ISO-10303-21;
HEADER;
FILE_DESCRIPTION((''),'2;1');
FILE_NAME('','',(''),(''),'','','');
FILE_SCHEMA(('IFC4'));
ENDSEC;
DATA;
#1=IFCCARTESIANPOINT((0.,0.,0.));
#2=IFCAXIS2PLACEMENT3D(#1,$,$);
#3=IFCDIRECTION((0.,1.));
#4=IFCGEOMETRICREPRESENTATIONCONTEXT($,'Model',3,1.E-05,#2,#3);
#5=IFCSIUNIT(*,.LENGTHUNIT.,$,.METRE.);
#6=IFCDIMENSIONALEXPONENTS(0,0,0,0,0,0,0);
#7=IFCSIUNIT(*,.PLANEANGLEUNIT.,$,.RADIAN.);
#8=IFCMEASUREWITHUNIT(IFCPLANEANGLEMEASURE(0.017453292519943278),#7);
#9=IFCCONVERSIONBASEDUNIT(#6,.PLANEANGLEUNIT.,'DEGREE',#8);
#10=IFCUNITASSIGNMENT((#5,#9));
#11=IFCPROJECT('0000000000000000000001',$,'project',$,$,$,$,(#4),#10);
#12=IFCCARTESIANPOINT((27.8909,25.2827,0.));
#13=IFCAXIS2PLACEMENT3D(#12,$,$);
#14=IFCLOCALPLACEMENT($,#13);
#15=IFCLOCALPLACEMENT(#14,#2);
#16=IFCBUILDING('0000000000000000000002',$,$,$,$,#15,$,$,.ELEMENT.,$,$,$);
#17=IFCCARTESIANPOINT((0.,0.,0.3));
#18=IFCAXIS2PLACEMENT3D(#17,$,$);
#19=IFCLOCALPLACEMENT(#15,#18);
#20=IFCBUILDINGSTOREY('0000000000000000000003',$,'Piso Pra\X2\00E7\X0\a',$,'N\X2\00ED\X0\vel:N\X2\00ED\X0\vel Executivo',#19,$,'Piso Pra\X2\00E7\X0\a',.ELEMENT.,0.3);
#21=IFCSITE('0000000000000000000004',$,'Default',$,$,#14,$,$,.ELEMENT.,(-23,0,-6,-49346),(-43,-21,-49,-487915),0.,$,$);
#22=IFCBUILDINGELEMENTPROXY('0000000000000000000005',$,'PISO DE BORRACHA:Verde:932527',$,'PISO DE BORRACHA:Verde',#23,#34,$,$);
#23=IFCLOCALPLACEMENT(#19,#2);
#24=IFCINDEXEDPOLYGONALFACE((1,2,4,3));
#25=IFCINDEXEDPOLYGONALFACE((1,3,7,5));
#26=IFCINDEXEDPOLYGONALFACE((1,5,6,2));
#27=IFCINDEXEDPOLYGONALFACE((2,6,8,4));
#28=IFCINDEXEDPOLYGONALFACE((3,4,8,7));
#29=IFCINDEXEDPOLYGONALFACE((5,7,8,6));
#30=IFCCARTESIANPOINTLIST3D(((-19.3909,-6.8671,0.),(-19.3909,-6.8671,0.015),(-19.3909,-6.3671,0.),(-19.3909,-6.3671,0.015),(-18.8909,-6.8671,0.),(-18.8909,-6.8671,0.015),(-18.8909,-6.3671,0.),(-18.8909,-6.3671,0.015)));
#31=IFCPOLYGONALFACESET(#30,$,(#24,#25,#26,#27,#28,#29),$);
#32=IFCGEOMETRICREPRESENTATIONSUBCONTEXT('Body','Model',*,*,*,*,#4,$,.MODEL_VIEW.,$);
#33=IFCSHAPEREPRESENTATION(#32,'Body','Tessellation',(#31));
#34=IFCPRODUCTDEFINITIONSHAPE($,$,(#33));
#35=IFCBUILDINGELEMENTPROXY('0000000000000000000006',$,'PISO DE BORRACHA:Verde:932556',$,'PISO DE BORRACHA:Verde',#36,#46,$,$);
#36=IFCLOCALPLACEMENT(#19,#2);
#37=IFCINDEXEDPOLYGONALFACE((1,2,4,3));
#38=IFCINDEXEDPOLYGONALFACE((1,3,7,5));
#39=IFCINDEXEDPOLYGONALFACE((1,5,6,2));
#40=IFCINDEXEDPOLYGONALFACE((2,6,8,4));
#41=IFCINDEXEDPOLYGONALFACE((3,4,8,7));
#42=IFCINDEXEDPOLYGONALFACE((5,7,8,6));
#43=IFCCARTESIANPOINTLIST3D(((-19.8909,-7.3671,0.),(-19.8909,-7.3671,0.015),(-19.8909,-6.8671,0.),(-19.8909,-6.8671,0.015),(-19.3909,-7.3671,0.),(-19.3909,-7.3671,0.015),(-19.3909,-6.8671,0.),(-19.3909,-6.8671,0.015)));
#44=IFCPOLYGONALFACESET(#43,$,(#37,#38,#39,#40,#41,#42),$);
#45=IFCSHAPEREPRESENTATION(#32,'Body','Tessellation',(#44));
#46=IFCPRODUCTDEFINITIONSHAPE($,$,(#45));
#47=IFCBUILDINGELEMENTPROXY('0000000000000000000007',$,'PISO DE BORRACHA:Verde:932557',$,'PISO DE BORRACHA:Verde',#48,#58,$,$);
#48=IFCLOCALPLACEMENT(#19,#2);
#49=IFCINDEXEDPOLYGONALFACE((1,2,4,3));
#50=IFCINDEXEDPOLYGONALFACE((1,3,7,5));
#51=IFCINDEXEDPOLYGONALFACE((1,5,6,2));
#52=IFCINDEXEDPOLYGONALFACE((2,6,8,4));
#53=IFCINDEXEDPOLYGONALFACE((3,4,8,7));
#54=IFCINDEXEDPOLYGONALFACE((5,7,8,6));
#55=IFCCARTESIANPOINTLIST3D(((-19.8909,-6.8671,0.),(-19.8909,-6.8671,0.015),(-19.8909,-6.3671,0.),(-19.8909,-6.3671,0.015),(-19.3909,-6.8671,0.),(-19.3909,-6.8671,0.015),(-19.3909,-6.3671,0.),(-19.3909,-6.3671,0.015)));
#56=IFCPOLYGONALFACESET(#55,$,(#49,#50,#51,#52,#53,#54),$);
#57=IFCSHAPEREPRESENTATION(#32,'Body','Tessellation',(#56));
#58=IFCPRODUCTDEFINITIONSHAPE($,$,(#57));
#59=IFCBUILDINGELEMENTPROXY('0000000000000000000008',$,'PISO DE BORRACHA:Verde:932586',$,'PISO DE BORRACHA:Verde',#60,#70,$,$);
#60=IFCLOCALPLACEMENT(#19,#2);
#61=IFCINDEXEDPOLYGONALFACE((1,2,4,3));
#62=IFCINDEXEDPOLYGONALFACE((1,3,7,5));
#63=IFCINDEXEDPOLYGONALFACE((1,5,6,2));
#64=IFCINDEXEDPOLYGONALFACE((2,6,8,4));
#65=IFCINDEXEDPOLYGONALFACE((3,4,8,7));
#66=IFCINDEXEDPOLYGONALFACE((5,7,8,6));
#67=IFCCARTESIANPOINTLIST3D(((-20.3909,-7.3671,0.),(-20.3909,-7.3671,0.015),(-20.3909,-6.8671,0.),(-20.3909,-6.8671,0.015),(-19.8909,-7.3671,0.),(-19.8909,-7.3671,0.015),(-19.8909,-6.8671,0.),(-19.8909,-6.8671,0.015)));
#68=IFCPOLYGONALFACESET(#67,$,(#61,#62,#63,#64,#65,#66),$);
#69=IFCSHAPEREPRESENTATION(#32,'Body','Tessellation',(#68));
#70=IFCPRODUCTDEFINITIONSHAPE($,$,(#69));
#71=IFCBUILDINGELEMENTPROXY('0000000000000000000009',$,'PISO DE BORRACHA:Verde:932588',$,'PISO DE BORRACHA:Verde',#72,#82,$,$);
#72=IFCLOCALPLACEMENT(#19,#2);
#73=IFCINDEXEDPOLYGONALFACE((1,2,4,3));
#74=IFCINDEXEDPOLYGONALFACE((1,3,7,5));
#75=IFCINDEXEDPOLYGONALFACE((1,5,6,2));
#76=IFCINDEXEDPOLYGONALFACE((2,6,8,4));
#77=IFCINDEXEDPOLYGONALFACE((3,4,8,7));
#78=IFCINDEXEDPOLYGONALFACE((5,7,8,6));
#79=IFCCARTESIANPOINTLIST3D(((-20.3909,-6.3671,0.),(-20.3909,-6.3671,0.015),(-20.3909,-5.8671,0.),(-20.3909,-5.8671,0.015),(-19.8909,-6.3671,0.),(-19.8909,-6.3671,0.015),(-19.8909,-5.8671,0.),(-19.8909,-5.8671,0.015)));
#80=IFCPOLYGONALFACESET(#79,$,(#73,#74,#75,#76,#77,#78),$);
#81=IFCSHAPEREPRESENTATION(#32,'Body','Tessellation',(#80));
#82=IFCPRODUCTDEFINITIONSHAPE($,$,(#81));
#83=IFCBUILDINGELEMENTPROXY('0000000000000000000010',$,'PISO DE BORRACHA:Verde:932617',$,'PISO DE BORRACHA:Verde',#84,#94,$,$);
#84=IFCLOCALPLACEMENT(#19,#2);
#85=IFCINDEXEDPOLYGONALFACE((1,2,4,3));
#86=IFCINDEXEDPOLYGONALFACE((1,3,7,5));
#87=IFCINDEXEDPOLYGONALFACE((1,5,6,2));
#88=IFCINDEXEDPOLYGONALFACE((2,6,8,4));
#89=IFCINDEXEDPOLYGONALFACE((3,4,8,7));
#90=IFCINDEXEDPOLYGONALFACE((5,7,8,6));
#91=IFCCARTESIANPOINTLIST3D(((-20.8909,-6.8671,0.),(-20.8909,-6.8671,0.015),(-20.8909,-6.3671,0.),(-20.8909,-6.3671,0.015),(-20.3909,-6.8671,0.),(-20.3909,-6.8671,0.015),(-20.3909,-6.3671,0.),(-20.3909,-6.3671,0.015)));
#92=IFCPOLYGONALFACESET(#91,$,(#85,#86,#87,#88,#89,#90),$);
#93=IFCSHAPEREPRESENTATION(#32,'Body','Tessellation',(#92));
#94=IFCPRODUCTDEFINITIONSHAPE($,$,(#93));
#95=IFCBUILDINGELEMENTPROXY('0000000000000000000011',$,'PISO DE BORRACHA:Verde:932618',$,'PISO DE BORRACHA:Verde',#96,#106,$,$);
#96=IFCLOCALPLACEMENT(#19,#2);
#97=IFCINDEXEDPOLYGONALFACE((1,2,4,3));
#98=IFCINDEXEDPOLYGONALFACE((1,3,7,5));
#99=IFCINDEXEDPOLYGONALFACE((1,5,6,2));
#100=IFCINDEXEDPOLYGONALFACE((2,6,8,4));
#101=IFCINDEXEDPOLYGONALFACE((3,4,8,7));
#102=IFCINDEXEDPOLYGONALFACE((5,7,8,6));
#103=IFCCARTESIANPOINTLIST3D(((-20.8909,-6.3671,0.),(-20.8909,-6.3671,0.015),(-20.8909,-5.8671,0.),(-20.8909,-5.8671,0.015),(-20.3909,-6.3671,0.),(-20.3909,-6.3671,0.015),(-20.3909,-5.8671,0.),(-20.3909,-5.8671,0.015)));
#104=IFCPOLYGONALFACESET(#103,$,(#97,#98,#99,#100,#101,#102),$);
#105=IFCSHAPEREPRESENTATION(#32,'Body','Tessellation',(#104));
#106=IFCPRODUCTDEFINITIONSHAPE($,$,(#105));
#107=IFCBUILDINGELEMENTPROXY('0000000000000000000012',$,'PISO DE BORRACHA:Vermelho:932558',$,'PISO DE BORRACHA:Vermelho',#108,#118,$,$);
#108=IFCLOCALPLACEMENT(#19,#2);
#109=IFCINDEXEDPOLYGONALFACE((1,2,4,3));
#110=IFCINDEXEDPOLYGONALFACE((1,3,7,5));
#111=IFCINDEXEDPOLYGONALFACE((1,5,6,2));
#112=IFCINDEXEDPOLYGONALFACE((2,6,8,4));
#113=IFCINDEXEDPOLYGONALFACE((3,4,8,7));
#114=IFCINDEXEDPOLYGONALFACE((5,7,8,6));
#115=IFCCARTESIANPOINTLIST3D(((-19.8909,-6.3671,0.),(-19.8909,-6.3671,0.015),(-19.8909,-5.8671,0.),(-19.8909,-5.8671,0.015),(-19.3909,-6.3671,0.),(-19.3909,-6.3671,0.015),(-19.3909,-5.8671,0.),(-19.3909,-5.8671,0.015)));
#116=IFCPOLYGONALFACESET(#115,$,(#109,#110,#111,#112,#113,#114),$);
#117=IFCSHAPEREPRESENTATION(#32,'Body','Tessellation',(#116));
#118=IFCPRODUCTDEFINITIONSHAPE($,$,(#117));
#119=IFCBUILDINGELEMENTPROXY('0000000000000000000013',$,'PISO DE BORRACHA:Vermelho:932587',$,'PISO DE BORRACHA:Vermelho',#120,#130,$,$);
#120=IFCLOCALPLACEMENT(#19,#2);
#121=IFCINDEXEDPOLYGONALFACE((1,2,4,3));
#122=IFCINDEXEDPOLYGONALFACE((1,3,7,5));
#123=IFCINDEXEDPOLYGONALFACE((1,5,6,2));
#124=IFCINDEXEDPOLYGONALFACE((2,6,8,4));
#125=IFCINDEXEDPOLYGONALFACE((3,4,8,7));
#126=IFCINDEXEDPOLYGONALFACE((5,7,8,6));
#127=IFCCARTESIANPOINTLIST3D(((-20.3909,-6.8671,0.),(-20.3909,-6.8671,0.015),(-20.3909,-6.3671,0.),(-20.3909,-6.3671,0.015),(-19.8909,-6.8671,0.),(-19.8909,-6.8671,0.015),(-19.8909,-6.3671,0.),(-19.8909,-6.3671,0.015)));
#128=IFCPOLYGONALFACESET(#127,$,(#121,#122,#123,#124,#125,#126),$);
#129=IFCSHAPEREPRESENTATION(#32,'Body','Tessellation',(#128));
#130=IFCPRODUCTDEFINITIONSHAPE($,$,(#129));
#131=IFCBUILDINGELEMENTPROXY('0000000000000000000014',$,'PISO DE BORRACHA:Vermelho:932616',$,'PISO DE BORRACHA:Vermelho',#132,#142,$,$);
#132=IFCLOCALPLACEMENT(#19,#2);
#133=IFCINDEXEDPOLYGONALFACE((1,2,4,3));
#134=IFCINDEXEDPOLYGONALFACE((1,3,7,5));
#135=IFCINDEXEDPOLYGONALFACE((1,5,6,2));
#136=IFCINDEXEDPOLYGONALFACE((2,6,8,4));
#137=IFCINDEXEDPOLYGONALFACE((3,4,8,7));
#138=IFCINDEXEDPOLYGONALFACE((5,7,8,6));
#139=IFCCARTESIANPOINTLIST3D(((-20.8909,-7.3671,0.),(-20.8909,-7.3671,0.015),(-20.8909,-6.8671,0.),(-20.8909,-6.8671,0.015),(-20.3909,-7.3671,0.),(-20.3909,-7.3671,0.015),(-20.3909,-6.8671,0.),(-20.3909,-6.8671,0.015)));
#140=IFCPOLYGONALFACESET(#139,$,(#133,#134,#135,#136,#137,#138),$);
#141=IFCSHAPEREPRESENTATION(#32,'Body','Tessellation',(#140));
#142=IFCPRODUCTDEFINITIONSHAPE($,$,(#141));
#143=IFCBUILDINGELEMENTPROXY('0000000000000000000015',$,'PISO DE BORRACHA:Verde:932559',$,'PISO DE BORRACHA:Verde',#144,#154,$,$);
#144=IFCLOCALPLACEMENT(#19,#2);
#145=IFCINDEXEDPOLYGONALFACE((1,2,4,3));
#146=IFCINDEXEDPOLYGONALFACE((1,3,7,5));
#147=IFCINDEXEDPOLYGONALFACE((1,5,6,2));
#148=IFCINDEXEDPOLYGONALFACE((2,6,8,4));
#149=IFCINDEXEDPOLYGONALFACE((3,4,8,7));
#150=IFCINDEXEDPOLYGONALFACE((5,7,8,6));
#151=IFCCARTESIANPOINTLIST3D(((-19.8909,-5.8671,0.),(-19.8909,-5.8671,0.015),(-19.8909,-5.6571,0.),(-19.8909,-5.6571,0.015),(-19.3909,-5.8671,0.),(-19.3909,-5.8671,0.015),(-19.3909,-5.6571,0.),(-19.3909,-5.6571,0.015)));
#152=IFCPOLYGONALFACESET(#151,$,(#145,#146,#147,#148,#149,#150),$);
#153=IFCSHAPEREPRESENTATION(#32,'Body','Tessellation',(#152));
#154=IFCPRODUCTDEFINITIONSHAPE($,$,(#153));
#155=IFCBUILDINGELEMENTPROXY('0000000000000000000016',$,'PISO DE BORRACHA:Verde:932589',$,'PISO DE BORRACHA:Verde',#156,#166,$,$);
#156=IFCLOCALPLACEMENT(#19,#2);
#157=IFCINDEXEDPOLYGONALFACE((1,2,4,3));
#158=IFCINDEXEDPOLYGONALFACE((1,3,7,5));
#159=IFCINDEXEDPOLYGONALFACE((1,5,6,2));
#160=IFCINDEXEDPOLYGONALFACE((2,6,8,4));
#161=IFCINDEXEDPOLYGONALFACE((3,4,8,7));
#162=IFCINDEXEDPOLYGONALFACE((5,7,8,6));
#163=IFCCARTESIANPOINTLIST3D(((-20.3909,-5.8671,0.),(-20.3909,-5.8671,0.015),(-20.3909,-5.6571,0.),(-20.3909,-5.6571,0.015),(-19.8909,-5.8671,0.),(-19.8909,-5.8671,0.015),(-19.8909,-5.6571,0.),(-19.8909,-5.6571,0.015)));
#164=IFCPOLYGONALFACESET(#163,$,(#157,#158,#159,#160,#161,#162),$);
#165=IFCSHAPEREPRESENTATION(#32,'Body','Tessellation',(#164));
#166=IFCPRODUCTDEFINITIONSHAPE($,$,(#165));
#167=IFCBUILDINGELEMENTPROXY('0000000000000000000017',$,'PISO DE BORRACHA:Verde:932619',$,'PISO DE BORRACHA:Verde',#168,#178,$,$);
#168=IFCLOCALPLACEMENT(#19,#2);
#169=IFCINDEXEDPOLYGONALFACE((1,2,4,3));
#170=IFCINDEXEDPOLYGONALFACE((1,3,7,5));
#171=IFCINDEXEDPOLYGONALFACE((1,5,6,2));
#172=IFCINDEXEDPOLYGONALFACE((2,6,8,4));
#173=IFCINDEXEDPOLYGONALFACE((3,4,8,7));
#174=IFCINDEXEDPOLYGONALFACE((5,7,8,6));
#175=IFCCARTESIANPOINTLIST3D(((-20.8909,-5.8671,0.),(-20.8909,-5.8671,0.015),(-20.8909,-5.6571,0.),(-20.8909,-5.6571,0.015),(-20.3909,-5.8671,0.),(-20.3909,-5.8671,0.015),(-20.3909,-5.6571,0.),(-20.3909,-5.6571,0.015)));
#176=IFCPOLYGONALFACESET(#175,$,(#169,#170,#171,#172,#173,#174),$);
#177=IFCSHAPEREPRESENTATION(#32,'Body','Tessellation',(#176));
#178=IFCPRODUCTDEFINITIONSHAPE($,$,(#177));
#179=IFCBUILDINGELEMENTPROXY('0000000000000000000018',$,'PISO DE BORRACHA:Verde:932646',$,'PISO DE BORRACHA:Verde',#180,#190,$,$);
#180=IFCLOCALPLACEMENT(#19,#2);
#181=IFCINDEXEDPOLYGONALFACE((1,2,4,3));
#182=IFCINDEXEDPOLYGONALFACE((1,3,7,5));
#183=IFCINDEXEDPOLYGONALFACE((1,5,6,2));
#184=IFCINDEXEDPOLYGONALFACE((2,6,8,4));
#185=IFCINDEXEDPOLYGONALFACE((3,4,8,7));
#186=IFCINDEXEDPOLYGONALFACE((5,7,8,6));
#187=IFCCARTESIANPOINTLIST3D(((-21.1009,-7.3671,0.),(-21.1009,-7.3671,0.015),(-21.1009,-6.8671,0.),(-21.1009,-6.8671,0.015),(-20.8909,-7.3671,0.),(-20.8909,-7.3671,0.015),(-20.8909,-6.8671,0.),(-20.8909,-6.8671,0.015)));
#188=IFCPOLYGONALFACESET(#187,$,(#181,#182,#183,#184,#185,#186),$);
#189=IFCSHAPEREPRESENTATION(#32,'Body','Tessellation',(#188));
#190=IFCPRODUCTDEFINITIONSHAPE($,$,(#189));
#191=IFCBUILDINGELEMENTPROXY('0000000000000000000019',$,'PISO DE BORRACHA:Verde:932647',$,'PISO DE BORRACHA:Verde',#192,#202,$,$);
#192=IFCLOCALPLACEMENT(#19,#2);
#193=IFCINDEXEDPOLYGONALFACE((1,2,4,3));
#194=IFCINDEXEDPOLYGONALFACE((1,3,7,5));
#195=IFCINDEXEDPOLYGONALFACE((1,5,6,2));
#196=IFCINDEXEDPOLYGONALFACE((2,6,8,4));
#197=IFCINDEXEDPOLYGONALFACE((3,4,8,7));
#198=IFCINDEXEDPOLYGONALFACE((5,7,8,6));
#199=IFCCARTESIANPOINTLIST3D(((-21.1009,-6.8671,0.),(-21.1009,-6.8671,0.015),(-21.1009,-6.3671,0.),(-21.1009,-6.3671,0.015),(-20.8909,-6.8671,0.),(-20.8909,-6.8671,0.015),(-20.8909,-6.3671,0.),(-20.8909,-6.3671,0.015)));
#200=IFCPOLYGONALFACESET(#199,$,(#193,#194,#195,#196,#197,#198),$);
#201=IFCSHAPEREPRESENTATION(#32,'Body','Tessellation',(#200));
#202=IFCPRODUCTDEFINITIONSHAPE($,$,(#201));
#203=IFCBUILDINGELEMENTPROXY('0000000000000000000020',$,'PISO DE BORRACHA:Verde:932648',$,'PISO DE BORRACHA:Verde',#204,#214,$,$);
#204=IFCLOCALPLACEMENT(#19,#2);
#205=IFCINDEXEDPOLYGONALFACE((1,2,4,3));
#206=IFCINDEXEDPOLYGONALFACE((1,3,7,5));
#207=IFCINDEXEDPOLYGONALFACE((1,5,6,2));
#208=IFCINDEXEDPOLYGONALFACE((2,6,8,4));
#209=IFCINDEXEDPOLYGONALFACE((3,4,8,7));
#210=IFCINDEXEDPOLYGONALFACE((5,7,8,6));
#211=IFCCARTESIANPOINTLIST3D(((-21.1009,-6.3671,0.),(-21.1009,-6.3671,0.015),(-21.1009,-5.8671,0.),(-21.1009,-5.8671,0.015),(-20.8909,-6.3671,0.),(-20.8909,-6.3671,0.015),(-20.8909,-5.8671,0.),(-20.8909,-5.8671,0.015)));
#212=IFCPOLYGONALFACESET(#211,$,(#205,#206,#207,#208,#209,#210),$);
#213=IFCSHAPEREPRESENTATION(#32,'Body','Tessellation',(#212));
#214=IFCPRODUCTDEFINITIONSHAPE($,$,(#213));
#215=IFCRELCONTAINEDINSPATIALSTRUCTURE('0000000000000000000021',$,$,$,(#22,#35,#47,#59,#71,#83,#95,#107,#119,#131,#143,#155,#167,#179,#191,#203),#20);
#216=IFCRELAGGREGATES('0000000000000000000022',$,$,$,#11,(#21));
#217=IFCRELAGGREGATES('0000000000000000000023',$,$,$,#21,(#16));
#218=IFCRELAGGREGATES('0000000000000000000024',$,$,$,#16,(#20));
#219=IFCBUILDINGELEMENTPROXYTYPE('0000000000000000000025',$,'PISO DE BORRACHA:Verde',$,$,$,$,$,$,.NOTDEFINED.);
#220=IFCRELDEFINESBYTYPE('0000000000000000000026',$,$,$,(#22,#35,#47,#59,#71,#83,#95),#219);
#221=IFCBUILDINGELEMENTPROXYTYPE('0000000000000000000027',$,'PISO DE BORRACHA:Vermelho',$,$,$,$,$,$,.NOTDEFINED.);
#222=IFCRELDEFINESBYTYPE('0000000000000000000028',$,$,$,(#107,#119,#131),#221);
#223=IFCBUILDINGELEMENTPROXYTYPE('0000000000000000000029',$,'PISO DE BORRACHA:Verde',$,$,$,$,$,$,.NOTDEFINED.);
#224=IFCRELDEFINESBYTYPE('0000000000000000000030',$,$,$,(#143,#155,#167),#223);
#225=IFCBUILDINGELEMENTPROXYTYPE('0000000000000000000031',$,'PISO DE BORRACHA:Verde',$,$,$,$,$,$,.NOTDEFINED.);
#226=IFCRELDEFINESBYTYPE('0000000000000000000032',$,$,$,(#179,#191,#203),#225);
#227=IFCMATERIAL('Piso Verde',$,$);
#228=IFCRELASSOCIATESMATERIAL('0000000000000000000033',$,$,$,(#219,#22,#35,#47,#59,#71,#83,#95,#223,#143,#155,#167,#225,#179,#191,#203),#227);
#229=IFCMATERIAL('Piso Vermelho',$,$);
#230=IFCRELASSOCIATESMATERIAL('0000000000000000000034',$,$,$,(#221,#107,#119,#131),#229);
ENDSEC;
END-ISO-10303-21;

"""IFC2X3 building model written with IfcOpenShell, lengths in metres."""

from ifc_helpers import new_model, entity, si_unit, converted_unit, direction, frame, frame_2d, origin, origin_2d_with_axis, place, context, subcontext, project, spatial, rectangle, extrude, source, transform, mapped, material, type_object, type_shapes, element, save


model = new_model("IFC2X3")

# Units and contexts
model_context = context("Model", 3, precision=1e-05, world=origin(), true_north=direction((0.0, 1.0)))
body_context = subcontext(model_context, "Body", "Model", "MODEL_VIEW")
ifc_project = project(units=[si_unit("LENGTHUNIT", "METRE"), converted_unit("PLANEANGLEUNIT", "DEGREE", entity("IfcPlaneAngleMeasure", 0.017453292519943278), si_unit("PLANEANGLEUNIT", "RADIAN"), dimensions=[0, 0, 0, 0, 0, 0, 0])], contexts=[model_context])

# Site, building, storey
site_placement = place(None, frame((27.8909, 25.2827, 0.0)))
site = spatial("IfcSite", under=ifc_project, at=site_placement, Name="Default", CompositionType="ELEMENT", RefLatitude=(-23, 0, -6, -49346), RefLongitude=(-43, -21, -49, -487915), RefElevation=0.0)
building_placement = place(site_placement, origin())
building = spatial("IfcBuilding", under=site, at=building_placement, CompositionType="ELEMENT")
storey_placement = place(building_placement, frame((0.0, 0.0, 0.3)))
storey = spatial("IfcBuildingStorey", under=building, at=storey_placement, Name="Piso Praça", ObjectType="Nível:Nível Executivo", LongName="Piso Praça", CompositionType="ELEMENT", Elevation=0.3)

# Building element proxies
ifc_material_1 = material(Name="Piso Verde")
building_element_proxy_type_1 = type_object("IfcBuildingElementProxyType", Name="PISO DE BORRACHA:Verde", PredefinedType="NOTDEFINED", material=ifc_material_1)
shared_shape_1 = source(origin(), body_context, "Body", "SweptSolid", [
    extrude(rectangle(XDim=0.5, YDim=0.5, at=origin_2d_with_axis()), frame((0.25, 0.25, 0.0), z_axis=(0.0, 0.0, 1.0), x_axis=(-1.0, 0.0, 0.0)), (0.0, 0.0, 1.0), 0.015),
])
type_shapes(building_element_proxy_type_1, [shared_shape_1])
for number, where, z_axis, x_axis, name in (
    (1, (-19.3909, -6.3671, 0.0), (0.0, 0.0, 1.0), (0.0, -1.0, 0.0), "PISO DE BORRACHA:Verde:932527"),
    (2, (-19.8909, -6.8671, 0.0), (0.0, 0.0, 1.0), (0.0, -1.0, 0.0), "PISO DE BORRACHA:Verde:932556"),
    (3, (-19.8909, -6.3671, 0.0), (0.0, 0.0, 1.0), (0.0, -1.0, 0.0), "PISO DE BORRACHA:Verde:932557"),
    (4, (-20.3909, -6.8671, 0.0), (0.0, 0.0, 1.0), (0.0, -1.0, 0.0), "PISO DE BORRACHA:Verde:932586"),
    (5, (-20.3909, -5.8671, 0.0), (0.0, 0.0, 1.0), (0.0, -1.0, 0.0), "PISO DE BORRACHA:Verde:932588"),
    (6, (-20.8909, -6.3671, 0.0), (0.0, 0.0, 1.0), (0.0, -1.0, 0.0), "PISO DE BORRACHA:Verde:932617"),
    (7, (-20.8909, -5.8671, 0.0), (0.0, 0.0, 1.0), (0.0, -1.0, 0.0), "PISO DE BORRACHA:Verde:932618"),
):
    element("IfcBuildingElementProxy", number, at=place(storey_placement, frame(where, z_axis=z_axis, x_axis=x_axis)), inside=storey, type_object=building_element_proxy_type_1, material=ifc_material_1, Name=name, ObjectType="PISO DE BORRACHA:Verde", context=body_context, shape_type="MappedRepresentation", body=[
        mapped(shared_shape_1, transform((0.0, 0.0, 0.0), scale=1.0)),
    ])
ifc_material_2 = material(Name="Piso Vermelho")
building_element_proxy_type_2 = type_object("IfcBuildingElementProxyType", Name="PISO DE BORRACHA:Vermelho", PredefinedType="NOTDEFINED", material=ifc_material_2)
shared_shape_2 = source(origin(), body_context, "Body", "SweptSolid", [
    extrude(rectangle(XDim=0.5, YDim=0.5, at=origin_2d_with_axis()), frame((0.25, 0.25, 0.0), z_axis=(0.0, 0.0, 1.0), x_axis=(-1.0, 0.0, 0.0)), (0.0, 0.0, 1.0), 0.015),
])
type_shapes(building_element_proxy_type_2, [shared_shape_2])
for number, where, z_axis, x_axis, name in (
    (8, (-19.8909, -5.8671, 0.0), (0.0, 0.0, 1.0), (0.0, -1.0, 0.0), "PISO DE BORRACHA:Vermelho:932558"),
    (9, (-20.3909, -6.3671, 0.0), (0.0, 0.0, 1.0), (0.0, -1.0, 0.0), "PISO DE BORRACHA:Vermelho:932587"),
    (10, (-20.8909, -6.8671, 0.0), (0.0, 0.0, 1.0), (0.0, -1.0, 0.0), "PISO DE BORRACHA:Vermelho:932616"),
):
    element("IfcBuildingElementProxy", number, at=place(storey_placement, frame(where, z_axis=z_axis, x_axis=x_axis)), inside=storey, type_object=building_element_proxy_type_2, material=ifc_material_2, Name=name, ObjectType="PISO DE BORRACHA:Vermelho", context=body_context, shape_type="MappedRepresentation", body=[
        mapped(shared_shape_2, transform((0.0, 0.0, 0.0), scale=1.0)),
    ])
building_element_proxy_type_3 = type_object("IfcBuildingElementProxyType", Name="PISO DE BORRACHA:Verde", PredefinedType="NOTDEFINED", material=ifc_material_1)
shared_shape_3 = source(origin(), body_context, "Body", "SweptSolid", [
    extrude(rectangle(XDim=0.21, YDim=0.5, at=frame_2d((0.0, 0.0), x_axis=(1.0, 0.0))), frame((0.105, 0.25, 0.0), z_axis=(0.0, 0.0, 1.0), x_axis=(-1.0, 0.0, 0.0)), (0.0, 0.0, 1.0), 0.015),
])
type_shapes(building_element_proxy_type_3, [shared_shape_3])
for number, where, z_axis, x_axis, name in (
    (11, (-19.8909, -5.6571, 0.0), (0.0, 0.0, 1.0), (0.0, -1.0, 0.0), "PISO DE BORRACHA:Verde:932559"),
    (12, (-20.3909, -5.6571, 0.0), (0.0, 0.0, 1.0), (0.0, -1.0, 0.0), "PISO DE BORRACHA:Verde:932589"),
    (13, (-20.8909, -5.6571, 0.0), (0.0, 0.0, 1.0), (0.0, -1.0, 0.0), "PISO DE BORRACHA:Verde:932619"),
):
    element("IfcBuildingElementProxy", number, at=place(storey_placement, frame(where, z_axis=z_axis, x_axis=x_axis)), inside=storey, type_object=building_element_proxy_type_3, material=ifc_material_1, Name=name, ObjectType="PISO DE BORRACHA:Verde", context=body_context, shape_type="MappedRepresentation", body=[
        mapped(shared_shape_3, transform((0.0, 0.0, 0.0), scale=1.0)),
    ])
building_element_proxy_type_4 = type_object("IfcBuildingElementProxyType", Name="PISO DE BORRACHA:Verde", PredefinedType="NOTDEFINED", material=ifc_material_1)
shared_shape_4 = source(origin(), body_context, "Body", "SweptSolid", [
    extrude(rectangle(XDim=0.5, YDim=0.21, at=origin_2d_with_axis()), frame((0.25, 0.105, 0.0), z_axis=(0.0, 0.0, 1.0), x_axis=(-1.0, 0.0, 0.0)), (0.0, 0.0, 1.0), 0.015),
])
type_shapes(building_element_proxy_type_4, [shared_shape_4])
for number, where, z_axis, x_axis, name in (
    (14, (-21.1009, -6.8671, 0.0), (0.0, 0.0, 1.0), (0.0, -1.0, 0.0), "PISO DE BORRACHA:Verde:932646"),
    (15, (-21.1009, -6.3671, 0.0), (0.0, 0.0, 1.0), (0.0, -1.0, 0.0), "PISO DE BORRACHA:Verde:932647"),
    (16, (-21.1009, -5.8671, 0.0), (0.0, 0.0, 1.0), (0.0, -1.0, 0.0), "PISO DE BORRACHA:Verde:932648"),
):
    element("IfcBuildingElementProxy", number, at=place(storey_placement, frame(where, z_axis=z_axis, x_axis=x_axis)), inside=storey, type_object=building_element_proxy_type_4, material=ifc_material_1, Name=name, ObjectType="PISO DE BORRACHA:Verde", context=body_context, shape_type="MappedRepresentation", body=[
        mapped(shared_shape_4, transform((0.0, 0.0, 0.0), scale=1.0)),
    ])

save(model, "model.ifc")
